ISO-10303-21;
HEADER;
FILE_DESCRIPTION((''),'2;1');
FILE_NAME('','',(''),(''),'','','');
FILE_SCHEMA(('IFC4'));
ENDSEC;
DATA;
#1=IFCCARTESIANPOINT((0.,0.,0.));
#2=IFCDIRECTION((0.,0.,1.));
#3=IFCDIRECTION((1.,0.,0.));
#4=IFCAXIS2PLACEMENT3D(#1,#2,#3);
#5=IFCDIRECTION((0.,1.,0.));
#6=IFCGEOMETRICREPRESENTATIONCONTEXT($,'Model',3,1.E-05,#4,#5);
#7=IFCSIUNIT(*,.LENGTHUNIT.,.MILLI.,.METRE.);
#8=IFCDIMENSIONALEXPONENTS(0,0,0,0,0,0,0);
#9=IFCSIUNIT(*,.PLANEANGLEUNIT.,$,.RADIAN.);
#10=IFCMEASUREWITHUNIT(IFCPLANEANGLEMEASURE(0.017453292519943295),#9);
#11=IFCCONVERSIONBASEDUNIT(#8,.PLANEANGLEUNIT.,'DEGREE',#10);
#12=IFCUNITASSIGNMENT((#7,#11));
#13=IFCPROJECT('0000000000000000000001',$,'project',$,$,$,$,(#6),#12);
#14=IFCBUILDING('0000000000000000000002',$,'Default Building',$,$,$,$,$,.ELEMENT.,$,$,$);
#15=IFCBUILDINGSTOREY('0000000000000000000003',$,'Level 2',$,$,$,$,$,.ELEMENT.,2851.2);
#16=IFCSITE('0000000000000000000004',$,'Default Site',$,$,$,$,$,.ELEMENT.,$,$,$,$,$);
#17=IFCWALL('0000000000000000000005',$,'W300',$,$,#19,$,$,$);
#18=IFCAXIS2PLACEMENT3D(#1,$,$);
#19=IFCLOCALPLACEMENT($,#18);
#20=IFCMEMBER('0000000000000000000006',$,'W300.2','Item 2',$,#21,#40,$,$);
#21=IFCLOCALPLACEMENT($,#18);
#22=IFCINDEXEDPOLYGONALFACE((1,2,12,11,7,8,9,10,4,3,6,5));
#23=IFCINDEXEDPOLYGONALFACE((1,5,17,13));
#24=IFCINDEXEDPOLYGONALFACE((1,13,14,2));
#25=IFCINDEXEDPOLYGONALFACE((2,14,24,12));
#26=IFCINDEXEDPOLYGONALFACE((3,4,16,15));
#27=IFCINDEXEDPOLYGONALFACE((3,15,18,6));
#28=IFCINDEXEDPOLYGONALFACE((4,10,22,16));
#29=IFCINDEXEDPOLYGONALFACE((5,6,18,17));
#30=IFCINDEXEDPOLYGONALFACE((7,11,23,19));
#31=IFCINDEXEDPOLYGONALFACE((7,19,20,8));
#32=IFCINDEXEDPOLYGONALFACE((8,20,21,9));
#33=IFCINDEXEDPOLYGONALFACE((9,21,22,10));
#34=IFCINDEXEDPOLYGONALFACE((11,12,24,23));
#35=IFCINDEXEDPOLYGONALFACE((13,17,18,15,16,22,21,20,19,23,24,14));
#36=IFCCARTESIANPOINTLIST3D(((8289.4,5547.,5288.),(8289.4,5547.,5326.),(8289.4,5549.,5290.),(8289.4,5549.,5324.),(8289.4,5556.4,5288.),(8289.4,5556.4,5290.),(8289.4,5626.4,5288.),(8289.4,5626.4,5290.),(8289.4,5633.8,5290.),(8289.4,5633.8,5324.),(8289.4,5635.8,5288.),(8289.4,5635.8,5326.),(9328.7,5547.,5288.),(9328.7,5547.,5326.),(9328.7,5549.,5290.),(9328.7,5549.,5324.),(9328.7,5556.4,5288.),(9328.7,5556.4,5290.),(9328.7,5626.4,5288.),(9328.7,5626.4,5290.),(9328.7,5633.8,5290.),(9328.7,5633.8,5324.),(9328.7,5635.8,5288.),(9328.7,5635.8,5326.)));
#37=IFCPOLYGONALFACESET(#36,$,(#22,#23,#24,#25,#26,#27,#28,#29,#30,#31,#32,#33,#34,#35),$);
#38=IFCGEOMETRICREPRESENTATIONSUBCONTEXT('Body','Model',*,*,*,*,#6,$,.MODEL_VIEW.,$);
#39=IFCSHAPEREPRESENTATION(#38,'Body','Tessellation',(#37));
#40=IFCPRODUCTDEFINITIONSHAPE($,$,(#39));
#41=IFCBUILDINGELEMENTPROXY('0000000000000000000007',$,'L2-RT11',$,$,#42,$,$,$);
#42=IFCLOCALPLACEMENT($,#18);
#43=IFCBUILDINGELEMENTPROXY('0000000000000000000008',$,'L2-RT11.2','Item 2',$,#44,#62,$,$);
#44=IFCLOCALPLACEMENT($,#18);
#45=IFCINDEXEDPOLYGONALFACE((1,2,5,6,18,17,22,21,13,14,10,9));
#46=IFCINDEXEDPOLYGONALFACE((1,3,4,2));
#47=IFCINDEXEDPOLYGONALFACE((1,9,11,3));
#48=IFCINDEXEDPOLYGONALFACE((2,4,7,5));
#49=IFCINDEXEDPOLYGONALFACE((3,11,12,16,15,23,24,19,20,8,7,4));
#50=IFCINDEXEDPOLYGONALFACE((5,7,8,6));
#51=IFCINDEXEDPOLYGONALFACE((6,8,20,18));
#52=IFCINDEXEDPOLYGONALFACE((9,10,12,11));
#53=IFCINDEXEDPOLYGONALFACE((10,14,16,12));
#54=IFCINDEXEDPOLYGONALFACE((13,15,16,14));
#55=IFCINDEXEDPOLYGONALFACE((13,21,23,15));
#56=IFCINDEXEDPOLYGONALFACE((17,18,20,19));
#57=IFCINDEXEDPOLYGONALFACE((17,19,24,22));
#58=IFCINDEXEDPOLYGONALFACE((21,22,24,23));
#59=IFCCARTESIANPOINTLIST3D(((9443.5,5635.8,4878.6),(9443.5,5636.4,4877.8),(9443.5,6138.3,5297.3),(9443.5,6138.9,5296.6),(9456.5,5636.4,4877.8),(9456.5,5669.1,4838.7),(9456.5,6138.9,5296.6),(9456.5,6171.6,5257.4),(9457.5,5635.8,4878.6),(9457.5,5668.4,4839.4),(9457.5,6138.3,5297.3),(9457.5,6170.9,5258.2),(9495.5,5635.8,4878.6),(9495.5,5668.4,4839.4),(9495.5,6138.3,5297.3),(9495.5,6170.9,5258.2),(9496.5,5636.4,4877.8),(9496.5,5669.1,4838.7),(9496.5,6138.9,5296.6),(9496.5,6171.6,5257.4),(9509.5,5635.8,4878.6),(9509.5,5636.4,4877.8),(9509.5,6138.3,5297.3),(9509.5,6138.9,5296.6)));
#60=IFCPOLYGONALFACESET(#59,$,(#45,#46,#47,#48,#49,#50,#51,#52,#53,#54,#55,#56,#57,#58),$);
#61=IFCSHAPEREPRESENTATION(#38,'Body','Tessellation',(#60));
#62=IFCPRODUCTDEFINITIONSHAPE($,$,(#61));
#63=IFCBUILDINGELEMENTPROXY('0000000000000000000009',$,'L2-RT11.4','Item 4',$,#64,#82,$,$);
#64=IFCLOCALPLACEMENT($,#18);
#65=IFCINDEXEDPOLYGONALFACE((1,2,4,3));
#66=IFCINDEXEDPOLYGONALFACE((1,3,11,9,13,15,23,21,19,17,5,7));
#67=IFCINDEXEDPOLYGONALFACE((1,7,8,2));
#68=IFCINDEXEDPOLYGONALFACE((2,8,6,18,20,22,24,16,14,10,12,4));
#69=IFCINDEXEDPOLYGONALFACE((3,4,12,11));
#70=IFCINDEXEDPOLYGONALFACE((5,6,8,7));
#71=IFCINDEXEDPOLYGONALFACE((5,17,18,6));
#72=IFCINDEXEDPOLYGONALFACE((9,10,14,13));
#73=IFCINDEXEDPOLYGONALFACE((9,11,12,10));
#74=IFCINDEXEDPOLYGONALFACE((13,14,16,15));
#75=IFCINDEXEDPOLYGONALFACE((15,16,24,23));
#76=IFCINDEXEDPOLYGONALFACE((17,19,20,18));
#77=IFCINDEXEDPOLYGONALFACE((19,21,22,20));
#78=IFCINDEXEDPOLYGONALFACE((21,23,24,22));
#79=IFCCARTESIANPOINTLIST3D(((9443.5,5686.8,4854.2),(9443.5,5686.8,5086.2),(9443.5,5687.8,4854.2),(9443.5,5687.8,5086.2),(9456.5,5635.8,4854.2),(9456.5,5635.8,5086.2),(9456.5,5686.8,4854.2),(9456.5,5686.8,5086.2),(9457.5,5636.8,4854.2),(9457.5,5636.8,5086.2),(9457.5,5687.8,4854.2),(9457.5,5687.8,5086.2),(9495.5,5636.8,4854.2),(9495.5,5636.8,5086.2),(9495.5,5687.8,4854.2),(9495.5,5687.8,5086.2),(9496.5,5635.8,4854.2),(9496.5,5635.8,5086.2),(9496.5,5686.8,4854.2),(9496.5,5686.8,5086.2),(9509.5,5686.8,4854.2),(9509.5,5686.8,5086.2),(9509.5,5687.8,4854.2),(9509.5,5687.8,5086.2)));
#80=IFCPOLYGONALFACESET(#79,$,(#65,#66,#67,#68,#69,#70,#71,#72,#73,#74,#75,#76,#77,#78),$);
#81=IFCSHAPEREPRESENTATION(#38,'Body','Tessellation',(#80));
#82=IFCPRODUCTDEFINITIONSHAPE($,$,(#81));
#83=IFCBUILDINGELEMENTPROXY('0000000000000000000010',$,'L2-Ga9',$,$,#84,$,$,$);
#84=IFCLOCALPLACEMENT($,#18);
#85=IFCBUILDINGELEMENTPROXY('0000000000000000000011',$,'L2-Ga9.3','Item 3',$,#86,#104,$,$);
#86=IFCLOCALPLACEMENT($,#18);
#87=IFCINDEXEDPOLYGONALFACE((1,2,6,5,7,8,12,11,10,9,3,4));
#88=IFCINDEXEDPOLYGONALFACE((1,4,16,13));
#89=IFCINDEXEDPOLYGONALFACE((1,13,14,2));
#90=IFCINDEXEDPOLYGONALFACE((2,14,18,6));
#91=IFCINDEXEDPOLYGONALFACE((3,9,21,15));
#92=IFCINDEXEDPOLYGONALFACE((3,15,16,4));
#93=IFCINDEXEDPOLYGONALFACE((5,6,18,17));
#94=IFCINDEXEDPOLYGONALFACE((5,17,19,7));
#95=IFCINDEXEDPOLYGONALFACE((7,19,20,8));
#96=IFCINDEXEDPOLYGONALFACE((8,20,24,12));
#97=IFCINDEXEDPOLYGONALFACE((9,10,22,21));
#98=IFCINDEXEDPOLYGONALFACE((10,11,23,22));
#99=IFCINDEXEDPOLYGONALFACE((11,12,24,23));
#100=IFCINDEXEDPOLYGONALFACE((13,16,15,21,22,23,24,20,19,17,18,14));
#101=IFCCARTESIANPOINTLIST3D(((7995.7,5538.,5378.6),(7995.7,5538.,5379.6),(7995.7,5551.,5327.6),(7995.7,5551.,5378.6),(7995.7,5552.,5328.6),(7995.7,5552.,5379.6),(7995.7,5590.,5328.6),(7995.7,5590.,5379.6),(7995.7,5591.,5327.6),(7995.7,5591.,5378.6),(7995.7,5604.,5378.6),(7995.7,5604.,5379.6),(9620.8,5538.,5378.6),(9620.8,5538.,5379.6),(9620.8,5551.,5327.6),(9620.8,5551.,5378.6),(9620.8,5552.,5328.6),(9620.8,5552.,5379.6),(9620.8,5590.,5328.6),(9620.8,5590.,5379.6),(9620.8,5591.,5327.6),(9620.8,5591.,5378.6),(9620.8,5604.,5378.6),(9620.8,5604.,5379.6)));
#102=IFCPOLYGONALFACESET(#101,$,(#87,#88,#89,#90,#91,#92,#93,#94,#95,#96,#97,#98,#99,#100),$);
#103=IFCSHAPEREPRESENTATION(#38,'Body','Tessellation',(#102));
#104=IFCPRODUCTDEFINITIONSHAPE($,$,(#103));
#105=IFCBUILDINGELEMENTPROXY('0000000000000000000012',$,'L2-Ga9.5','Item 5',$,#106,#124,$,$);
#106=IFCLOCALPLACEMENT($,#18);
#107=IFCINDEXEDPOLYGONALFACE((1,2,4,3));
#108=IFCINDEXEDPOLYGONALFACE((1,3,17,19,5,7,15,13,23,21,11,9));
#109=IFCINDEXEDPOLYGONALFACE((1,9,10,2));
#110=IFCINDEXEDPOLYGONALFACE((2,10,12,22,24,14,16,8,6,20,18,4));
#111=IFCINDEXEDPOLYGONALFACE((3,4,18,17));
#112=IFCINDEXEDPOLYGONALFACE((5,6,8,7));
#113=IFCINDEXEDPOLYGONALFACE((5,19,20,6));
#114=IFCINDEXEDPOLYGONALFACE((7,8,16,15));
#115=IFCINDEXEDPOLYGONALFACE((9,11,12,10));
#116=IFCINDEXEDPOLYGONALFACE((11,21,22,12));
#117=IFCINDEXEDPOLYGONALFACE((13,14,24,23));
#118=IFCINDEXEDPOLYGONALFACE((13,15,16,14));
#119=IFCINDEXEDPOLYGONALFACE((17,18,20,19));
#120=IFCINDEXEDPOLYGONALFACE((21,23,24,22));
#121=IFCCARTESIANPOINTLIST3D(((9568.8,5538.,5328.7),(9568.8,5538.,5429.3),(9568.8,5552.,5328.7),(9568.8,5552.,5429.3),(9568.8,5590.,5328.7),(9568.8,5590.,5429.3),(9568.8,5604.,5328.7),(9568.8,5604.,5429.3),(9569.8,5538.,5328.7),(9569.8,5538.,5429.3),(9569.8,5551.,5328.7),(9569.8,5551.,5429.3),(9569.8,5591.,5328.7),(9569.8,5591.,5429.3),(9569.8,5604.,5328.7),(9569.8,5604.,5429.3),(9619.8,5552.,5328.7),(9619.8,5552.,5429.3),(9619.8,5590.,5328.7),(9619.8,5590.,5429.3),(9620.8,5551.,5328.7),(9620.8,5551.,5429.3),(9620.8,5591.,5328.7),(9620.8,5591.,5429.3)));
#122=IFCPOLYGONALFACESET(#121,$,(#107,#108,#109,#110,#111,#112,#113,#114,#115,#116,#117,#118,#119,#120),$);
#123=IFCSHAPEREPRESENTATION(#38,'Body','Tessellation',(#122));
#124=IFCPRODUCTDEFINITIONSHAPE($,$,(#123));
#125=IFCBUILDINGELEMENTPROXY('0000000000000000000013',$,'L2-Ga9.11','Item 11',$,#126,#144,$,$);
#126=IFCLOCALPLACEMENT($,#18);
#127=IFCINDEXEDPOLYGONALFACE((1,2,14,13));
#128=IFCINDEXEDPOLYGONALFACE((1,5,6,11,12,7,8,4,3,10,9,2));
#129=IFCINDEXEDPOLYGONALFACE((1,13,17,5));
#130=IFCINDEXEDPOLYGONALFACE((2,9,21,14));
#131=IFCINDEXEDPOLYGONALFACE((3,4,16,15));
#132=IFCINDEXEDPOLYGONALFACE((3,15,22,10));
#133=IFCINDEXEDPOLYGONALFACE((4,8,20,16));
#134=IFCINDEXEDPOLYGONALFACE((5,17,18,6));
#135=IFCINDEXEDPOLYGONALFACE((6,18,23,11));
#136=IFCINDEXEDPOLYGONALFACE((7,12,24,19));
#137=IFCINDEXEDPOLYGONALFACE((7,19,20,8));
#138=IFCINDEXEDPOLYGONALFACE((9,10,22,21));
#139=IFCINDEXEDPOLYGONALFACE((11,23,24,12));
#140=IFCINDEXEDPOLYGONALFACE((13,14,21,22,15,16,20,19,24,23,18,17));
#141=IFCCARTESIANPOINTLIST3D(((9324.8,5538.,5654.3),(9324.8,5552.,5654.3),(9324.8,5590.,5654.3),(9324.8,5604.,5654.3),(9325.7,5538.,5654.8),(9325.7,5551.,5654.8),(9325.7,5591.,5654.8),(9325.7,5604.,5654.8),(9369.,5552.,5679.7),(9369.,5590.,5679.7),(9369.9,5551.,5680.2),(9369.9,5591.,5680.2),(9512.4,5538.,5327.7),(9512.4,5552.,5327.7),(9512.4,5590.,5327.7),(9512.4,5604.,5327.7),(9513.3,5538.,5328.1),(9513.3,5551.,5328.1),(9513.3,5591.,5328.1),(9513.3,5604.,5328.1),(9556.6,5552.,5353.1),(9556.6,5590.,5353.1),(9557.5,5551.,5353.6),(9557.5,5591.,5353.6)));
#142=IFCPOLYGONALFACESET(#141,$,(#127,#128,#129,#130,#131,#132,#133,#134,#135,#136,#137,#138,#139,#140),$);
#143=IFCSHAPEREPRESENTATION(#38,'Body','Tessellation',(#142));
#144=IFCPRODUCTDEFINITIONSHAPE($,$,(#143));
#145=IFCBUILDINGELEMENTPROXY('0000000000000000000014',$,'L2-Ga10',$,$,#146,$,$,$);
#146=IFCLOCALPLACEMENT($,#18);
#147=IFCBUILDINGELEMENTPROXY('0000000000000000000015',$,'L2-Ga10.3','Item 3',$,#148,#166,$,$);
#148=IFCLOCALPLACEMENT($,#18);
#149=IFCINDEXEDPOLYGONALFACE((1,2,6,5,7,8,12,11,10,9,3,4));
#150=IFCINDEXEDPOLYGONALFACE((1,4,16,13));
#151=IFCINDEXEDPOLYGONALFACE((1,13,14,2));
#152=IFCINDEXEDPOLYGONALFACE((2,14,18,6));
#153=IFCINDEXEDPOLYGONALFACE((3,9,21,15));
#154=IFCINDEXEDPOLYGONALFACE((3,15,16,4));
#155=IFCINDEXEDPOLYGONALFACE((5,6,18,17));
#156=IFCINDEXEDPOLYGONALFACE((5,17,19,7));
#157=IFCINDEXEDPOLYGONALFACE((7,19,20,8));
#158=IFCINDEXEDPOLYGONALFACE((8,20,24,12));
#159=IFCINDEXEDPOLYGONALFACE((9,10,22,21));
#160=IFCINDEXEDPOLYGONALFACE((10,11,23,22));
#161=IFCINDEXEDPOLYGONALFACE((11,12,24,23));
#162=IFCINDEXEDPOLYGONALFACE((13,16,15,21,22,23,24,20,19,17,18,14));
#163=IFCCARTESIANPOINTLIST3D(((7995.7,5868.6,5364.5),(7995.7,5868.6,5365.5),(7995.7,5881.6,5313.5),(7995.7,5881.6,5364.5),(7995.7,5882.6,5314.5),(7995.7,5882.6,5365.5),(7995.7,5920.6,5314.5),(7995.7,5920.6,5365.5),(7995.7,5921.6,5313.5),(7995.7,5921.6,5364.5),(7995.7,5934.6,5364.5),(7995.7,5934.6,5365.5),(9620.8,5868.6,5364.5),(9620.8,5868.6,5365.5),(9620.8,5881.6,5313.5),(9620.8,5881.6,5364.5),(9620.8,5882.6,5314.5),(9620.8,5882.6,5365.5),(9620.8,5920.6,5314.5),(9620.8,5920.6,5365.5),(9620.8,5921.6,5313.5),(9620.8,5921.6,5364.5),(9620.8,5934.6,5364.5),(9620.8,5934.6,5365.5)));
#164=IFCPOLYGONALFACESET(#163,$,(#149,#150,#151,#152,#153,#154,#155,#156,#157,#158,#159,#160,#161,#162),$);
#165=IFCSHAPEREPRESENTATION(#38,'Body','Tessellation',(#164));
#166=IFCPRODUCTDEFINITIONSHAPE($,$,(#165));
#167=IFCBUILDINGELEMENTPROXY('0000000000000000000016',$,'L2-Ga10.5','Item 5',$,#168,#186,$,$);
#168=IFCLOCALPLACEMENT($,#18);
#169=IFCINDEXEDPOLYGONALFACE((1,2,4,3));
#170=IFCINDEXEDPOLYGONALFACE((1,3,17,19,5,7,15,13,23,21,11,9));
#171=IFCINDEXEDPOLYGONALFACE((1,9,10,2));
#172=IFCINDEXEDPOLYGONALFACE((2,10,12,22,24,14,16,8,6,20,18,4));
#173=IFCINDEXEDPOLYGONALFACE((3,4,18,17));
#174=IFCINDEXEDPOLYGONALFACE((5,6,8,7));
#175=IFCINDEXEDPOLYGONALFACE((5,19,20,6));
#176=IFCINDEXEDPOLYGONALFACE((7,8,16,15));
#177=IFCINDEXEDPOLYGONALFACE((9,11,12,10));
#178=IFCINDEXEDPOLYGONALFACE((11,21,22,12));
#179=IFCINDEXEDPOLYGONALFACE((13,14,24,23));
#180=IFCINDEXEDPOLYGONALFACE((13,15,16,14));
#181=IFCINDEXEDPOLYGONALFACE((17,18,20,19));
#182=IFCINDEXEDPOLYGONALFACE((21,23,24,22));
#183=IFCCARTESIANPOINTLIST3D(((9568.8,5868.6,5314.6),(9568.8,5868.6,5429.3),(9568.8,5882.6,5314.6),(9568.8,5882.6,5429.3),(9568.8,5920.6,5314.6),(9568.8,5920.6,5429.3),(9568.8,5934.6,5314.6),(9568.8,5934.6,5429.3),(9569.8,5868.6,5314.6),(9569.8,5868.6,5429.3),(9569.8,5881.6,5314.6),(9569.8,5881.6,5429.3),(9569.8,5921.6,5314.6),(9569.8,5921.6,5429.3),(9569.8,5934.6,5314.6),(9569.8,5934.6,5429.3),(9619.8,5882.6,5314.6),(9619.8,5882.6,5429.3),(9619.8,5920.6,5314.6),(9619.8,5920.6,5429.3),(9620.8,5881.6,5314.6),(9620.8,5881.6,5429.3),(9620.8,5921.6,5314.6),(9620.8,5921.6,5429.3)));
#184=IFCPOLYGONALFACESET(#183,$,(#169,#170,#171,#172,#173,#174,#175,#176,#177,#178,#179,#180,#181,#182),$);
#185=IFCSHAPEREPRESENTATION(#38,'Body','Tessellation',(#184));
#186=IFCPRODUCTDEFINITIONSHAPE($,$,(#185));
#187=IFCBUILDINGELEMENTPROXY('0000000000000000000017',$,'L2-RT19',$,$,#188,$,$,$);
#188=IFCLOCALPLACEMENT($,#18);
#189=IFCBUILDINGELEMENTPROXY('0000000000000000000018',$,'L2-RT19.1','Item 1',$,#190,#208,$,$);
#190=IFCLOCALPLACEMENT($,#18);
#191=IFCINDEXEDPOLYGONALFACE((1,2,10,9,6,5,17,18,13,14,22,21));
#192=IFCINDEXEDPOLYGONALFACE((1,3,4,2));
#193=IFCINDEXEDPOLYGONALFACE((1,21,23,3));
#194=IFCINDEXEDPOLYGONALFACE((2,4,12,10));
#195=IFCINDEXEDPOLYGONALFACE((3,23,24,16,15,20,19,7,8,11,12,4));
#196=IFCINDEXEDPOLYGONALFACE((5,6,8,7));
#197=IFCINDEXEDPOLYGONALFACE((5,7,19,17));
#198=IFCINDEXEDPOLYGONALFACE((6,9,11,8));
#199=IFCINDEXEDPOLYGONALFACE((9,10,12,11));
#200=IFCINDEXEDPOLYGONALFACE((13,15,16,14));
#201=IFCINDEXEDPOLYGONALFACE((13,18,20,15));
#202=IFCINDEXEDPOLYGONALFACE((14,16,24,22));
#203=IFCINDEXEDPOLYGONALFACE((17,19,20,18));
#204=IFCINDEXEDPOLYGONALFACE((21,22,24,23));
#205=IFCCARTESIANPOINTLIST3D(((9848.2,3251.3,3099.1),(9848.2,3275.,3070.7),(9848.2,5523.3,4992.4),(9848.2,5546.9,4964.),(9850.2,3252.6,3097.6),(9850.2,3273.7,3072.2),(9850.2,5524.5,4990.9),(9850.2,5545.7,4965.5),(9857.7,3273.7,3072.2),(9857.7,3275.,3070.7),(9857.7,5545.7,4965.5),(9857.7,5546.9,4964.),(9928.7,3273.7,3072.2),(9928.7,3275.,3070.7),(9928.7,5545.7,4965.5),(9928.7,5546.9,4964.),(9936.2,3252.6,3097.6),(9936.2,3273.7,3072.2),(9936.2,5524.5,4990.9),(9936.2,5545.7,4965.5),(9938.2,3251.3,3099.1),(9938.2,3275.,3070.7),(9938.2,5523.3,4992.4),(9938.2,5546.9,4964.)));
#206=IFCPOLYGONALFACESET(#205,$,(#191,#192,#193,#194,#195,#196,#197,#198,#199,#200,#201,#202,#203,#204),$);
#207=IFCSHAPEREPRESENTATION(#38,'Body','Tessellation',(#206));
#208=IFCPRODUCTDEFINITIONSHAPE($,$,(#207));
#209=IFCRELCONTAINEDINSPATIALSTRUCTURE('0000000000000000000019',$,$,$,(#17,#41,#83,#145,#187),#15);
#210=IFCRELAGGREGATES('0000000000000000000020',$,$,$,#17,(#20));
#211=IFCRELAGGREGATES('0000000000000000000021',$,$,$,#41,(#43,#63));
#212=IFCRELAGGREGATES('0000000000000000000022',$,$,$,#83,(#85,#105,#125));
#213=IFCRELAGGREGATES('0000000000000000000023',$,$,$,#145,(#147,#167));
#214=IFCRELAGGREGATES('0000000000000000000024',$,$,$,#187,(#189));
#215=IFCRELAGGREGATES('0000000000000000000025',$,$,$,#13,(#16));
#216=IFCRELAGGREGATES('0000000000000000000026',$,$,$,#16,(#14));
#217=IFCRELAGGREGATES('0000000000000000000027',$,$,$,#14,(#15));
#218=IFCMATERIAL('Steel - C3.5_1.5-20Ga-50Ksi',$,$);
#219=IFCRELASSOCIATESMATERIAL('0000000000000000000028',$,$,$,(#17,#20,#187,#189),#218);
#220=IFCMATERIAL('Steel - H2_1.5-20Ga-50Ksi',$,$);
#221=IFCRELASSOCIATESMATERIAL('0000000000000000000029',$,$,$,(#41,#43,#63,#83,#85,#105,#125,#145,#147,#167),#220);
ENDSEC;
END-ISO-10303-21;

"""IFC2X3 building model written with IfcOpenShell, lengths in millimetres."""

from ifc_helpers import new_model, entity, si_unit, converted_unit, direction, frame, origin, origin_with_axes, origin_2d_with_axis, place, context, subcontext, project, spatial, polyline, c_section, outline, extrude, material, element, aggregate, save


model = new_model("IFC2X3")

# Units and contexts
model_context = context("Model", 3, precision=1e-05, world=origin_with_axes(), true_north=direction((0.0, 1.0, 0.0)))
body_context = subcontext(model_context, "Body", "Model", "MODEL_VIEW")
ifc_project = project(units=[si_unit("LENGTHUNIT", "METRE", prefix="MILLI"), converted_unit("PLANEANGLEUNIT", "DEGREE", entity("IfcPlaneAngleMeasure", 0.017453292519943295), si_unit("PLANEANGLEUNIT", "RADIAN"), dimensions=[0, 0, 0, 0, 0, 0, 0])], contexts=[model_context])

# Site, building, storey
site = spatial("IfcSite", under=ifc_project, Name="Default Site", CompositionType="ELEMENT")
building = spatial("IfcBuilding", under=site, Name="Default Building", CompositionType="ELEMENT")
storey = spatial("IfcBuildingStorey", under=building, Name="Level 2", CompositionType="ELEMENT", Elevation=2851.2)

# Wall, member
ifc_material_1 = material(Name="Steel - C3.5_1.5-20Ga-50Ksi")
wall_1 = element("IfcWall", 1, inside=storey, material=ifc_material_1, Name="W300")
member_1_placement = place(None, frame((9328.7, 5591.4, 5307.0), z_axis=(-1.0, 0.0, 0.0), x_axis=(0.0, 0.0, -1.0)))
member_1 = element("IfcMember", 2, at=member_1_placement, material=ifc_material_1, Name="W300.2", Description="Item 2", context=body_context, shape_type="SweptSolid", body=[
    extrude(c_section(Depth=88.9, Width=38.1, WallThickness=2.0, Girth=9.5, at=origin_2d_with_axis()), origin(), (0.0, 0.0, 1.0), 1039.3),
])
aggregate(wall_1, [member_1])

# Building element proxies
ifc_material_2 = material(Name="Steel - H2_1.5-20Ga-50Ksi")
proxy_1 = element("IfcBuildingElementProxy", 3, inside=storey, material=ifc_material_2, Name="L2-RT11")
proxy_2_placement = place(None, frame((9443.5, 5635.8, 4878.6), z_axis=(0.0, 0.768, 0.64), x_axis=(40.0, 0.0, 0.0)))
proxy_2 = element("IfcBuildingElementProxy", 4, at=proxy_2_placement, material=ifc_material_2, Name="L2-RT11.2", Description="Item 2", context=body_context, shape_type="SweptSolid", body=[
    extrude(outline(polyline([(0.0, 0.0), (14.0, 0.0), (14.0, 51.0), (52.0, 51.0), (52.0, 0.0), (66.0, 0.0), (66.0, 1.0), (53.0, 1.0), (53.0, 52.0), (13.0, 52.0), (13.0, 1.0), (0.0, 1.0), (0.0, 0.0)])), origin(), (0.0, 0.0, 1.0), 654.1),
])
proxy_3_placement = place(None, frame((9443.5, 5687.8, 5086.2), z_axis=(0.0, 0.0, -1.0), x_axis=(40.0, 0.0, 0.0)))
proxy_3 = element("IfcBuildingElementProxy", 5, at=proxy_3_placement, material=ifc_material_2, Name="L2-RT11.4", Description="Item 4", context=body_context, shape_type="SweptSolid", body=[
    extrude(outline(polyline([(0.0, 0.0), (14.0, 0.0), (14.0, 51.0), (52.0, 51.0), (52.0, 0.0), (66.0, 0.0), (66.0, 1.0), (53.0, 1.0), (53.0, 52.0), (13.0, 52.0), (13.0, 1.0), (0.0, 1.0), (0.0, 0.0)])), origin(), (0.0, 0.0, 1.0), 232.0),
])
aggregate(proxy_1, [proxy_2, proxy_3])
proxy_4 = element("IfcBuildingElementProxy", 6, inside=storey, material=ifc_material_2, Name="L2-Ga9")
proxy_5_placement = place(None, frame((9620.8, 5538.0, 5379.6), z_axis=(-1.0, 0.0, 0.0), x_axis=(0.0, 40.0, 0.0)))
proxy_5 = element("IfcBuildingElementProxy", 7, at=proxy_5_placement, material=ifc_material_2, Name="L2-Ga9.3", Description="Item 3", context=body_context, shape_type="SweptSolid", body=[
    extrude(outline(polyline([(0.0, 0.0), (14.0, 0.0), (14.0, 51.0), (52.0, 51.0), (52.0, 0.0), (66.0, 0.0), (66.0, 1.0), (53.0, 1.0), (53.0, 52.0), (13.0, 52.0), (13.0, 1.0), (0.0, 1.0), (0.0, 0.0)])), origin(), (0.0, 0.0, 1.0), 1625.1),
])
proxy_6_placement = place(None, frame((9568.8, 5538.0, 5429.3), z_axis=(0.0, 0.0, -1.0), x_axis=(0.0, 40.0, 0.0)))
proxy_6 = element("IfcBuildingElementProxy", 8, at=proxy_6_placement, material=ifc_material_2, Name="L2-Ga9.5", Description="Item 5", context=body_context, shape_type="SweptSolid", body=[
    extrude(outline(polyline([(0.0, 0.0), (14.0, 0.0), (14.0, 51.0), (52.0, 51.0), (52.0, 0.0), (66.0, 0.0), (66.0, 1.0), (53.0, 1.0), (53.0, 52.0), (13.0, 52.0), (13.0, 1.0), (0.0, 1.0), (0.0, 0.0)])), origin(), (0.0, 0.0, 1.0), 100.6),
])
proxy_7_placement = place(None, frame((9324.8, 5538.0, 5654.3), z_axis=(0.498, 0.0, -0.867), x_axis=(0.0, 40.0, 0.0)))
proxy_7 = element("IfcBuildingElementProxy", 9, at=proxy_7_placement, material=ifc_material_2, Name="L2-Ga9.11", Description="Item 11", context=body_context, shape_type="SweptSolid", body=[
    extrude(outline(polyline([(0.0, 0.0), (14.0, 0.0), (14.0, 51.0), (52.0, 51.0), (52.0, 0.0), (66.0, 0.0), (66.0, 1.0), (53.0, 1.0), (53.0, 52.0), (13.0, 52.0), (13.0, 1.0), (0.0, 1.0), (0.0, 0.0)])), origin(), (0.0, 0.0, 1.0), 376.7),
])
aggregate(proxy_4, [proxy_5, proxy_6, proxy_7])
proxy_8 = element("IfcBuildingElementProxy", 10, inside=storey, material=ifc_material_2, Name="L2-Ga10")
proxy_9_placement = place(None, frame((9620.8, 5868.6, 5365.5), z_axis=(-1.0, 0.0, 0.0), x_axis=(0.0, 40.0, 0.0)))
proxy_9 = element("IfcBuildingElementProxy", 11, at=proxy_9_placement, material=ifc_material_2, Name="L2-Ga10.3", Description="Item 3", context=body_context, shape_type="SweptSolid", body=[
    extrude(outline(polyline([(0.0, 0.0), (14.0, 0.0), (14.0, 51.0), (52.0, 51.0), (52.0, 0.0), (66.0, 0.0), (66.0, 1.0), (53.0, 1.0), (53.0, 52.0), (13.0, 52.0), (13.0, 1.0), (0.0, 1.0), (0.0, 0.0)])), origin(), (0.0, 0.0, 1.0), 1625.1),
])
proxy_10_placement = place(None, frame((9568.8, 5868.6, 5429.3), z_axis=(0.0, 0.0, -1.0), x_axis=(0.0, 40.0, 0.0)))
proxy_10 = element("IfcBuildingElementProxy", 12, at=proxy_10_placement, material=ifc_material_2, Name="L2-Ga10.5", Description="Item 5", context=body_context, shape_type="SweptSolid", body=[
    extrude(outline(polyline([(0.0, 0.0), (14.0, 0.0), (14.0, 51.0), (52.0, 51.0), (52.0, 0.0), (66.0, 0.0), (66.0, 1.0), (53.0, 1.0), (53.0, 52.0), (13.0, 52.0), (13.0, 1.0), (0.0, 1.0), (0.0, 0.0)])), origin(), (0.0, 0.0, 1.0), 114.7),
])
aggregate(proxy_8, [proxy_9, proxy_10])
proxy_11 = element("IfcBuildingElementProxy", 13, inside=storey, material=ifc_material_1, Name="L2-RT19")
proxy_12_placement = place(None, frame((9893.2, 5535.1, 4978.2), z_axis=(0.0, -0.768, -0.64), x_axis=(0.0, 23.689, -28.422)))
proxy_12 = element("IfcBuildingElementProxy", 14, at=proxy_12_placement, material=ifc_material_1, Name="L2-RT19.1", Description="Item 1", context=body_context, shape_type="SweptSolid", body=[
    extrude(c_section(Depth=90.0, Width=37.0, WallThickness=2.0, Girth=9.5, at=origin_2d_with_axis()), origin(), (0.0, 0.0, 1.0), 2957.4),
])
aggregate(proxy_11, [proxy_12])

save(model, "model.ifc")
